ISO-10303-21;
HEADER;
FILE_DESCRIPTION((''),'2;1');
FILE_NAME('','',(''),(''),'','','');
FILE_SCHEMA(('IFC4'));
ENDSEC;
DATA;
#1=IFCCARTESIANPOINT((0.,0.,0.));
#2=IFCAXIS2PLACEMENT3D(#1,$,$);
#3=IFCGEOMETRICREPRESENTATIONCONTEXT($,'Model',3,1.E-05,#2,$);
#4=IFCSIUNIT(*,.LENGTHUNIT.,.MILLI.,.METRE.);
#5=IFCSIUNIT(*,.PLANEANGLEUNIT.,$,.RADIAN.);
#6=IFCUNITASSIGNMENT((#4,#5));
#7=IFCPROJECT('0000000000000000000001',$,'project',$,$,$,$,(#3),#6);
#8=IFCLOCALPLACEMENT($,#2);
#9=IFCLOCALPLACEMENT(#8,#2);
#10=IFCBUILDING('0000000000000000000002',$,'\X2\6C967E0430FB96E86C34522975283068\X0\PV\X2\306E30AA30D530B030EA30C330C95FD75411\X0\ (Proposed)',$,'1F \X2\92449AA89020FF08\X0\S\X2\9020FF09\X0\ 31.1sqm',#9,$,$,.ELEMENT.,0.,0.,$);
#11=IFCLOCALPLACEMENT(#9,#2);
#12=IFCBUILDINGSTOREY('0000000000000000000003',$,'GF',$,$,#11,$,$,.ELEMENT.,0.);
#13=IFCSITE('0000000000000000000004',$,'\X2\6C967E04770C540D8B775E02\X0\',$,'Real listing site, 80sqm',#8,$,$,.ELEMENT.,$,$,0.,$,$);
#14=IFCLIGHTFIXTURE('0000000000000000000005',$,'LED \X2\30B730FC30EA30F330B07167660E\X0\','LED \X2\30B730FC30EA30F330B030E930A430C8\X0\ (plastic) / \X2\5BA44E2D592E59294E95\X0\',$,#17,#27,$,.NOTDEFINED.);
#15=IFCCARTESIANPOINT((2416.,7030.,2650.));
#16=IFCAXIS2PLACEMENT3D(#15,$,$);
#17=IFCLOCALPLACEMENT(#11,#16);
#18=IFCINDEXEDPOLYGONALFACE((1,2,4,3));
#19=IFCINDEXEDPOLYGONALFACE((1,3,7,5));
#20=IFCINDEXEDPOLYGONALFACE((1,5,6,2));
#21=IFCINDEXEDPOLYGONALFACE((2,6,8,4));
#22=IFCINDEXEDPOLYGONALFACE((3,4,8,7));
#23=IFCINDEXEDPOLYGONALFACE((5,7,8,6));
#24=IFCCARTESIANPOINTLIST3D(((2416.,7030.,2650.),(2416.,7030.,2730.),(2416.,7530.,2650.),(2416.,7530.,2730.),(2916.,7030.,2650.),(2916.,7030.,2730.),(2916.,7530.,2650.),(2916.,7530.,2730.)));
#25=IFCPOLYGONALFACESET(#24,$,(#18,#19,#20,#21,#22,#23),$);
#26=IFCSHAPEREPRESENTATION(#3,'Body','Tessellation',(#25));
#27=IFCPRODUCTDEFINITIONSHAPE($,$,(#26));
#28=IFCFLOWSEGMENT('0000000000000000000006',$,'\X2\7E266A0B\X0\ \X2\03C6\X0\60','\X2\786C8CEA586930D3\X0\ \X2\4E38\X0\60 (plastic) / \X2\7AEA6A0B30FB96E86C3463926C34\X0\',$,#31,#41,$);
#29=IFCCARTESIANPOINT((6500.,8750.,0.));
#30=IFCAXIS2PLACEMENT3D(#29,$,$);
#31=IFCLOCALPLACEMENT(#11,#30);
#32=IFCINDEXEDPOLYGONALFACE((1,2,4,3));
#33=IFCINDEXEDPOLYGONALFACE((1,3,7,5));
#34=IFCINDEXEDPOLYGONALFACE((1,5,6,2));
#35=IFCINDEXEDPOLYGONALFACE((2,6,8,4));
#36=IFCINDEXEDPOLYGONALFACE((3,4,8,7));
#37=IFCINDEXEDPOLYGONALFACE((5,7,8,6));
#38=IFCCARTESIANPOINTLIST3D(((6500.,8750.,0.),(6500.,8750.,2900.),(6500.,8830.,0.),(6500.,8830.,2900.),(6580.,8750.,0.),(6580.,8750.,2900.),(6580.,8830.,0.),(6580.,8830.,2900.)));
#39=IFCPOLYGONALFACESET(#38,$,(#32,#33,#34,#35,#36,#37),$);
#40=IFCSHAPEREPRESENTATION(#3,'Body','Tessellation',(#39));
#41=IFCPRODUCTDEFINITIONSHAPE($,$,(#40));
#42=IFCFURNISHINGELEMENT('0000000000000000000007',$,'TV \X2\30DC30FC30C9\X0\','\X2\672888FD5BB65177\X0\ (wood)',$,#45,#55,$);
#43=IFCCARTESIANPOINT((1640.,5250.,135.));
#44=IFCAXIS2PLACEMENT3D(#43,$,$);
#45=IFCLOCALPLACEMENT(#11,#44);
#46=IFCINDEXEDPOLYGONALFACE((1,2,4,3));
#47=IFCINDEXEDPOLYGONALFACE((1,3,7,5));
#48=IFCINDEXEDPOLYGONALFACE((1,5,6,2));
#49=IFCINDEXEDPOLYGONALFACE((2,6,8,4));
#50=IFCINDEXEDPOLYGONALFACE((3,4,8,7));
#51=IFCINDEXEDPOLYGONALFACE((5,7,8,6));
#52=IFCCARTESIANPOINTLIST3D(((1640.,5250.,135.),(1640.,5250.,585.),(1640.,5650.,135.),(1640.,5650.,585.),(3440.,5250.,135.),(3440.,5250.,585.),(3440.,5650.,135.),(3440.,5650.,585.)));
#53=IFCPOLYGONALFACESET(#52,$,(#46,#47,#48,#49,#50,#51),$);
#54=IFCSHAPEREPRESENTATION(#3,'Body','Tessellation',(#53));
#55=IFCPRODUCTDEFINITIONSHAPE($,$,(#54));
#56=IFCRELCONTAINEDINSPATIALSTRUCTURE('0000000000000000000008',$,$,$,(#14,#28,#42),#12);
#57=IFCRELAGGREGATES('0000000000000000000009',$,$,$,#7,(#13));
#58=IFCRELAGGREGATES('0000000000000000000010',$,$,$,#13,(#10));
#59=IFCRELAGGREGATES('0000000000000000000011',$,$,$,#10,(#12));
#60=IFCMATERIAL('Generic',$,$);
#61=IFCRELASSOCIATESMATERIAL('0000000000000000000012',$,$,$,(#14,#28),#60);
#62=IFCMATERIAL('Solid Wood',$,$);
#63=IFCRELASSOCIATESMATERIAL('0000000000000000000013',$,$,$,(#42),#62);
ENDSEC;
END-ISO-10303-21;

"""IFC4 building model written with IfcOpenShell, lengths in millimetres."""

from ifc_helpers import new_model, si_unit, frame, frame_2d, origin, place, context, project, spatial, rectangle, extrude, material, element, save


model = new_model("IFC4")

# Units and contexts
model_context = context("Model", 3, precision=1e-05, world=origin())
ifc_project = project(units=[si_unit("LENGTHUNIT", "METRE", prefix="MILLI"), si_unit("PLANEANGLEUNIT", "RADIAN")], contexts=[model_context])

# Site, building, storey
site_placement = place(None, origin())
site = spatial("IfcSite", under=ifc_project, at=site_placement, Name="沖縄県名護市", ObjectType="Real listing site, 80sqm", CompositionType="ELEMENT", RefElevation=0.0)
building_placement = place(site_placement, origin())
building = spatial("IfcBuilding", under=site, at=building_placement, Name="沖縄・雨水利用とPVのオフグリッド志向 (Proposed)", ObjectType="1F 鉄骨造（S造） 31.1sqm", CompositionType="ELEMENT", ElevationOfRefHeight=0.0, ElevationOfTerrain=0.0)
storey_placement = place(building_placement, origin())
storey = spatial("IfcBuildingStorey", under=building, at=storey_placement, Name="GF", CompositionType="ELEMENT", Elevation=0.0)

# Shared definitions
ifc_material_1 = material(Name="Solid Wood")

# Shared definitions
ifc_material_2 = material(Name="Generic")

# Light fixture
light_fixture_1_placement = place(storey_placement, frame((2416.0, 7030.0, 2650.0)))
element("IfcLightFixture", 1, at=light_fixture_1_placement, inside=storey, material=ifc_material_2, Name="LED シーリング照明", Description="LED シーリングライト (plastic) / 室中央天井", PredefinedType="NOTDEFINED", context=model_context, shape_type="SweptSolid", body=[
    extrude(rectangle(XDim=500.0, YDim=500.0, at=frame_2d((250.0, 250.0))), frame((2416.0, 7030.0, 2650.0)), (0.0, 0.0, 1.0), 80.0),
])

# Flow segment
flow_segment_placement = place(storey_placement, frame((6500.0, 8750.0, 0.0)))
element("IfcFlowSegment", 2, at=flow_segment_placement, inside=storey, material=ifc_material_2, Name="縦樋 φ60", Description="硬質塩ビ 丸60 (plastic) / 竪樋・雨水排水", context=model_context, shape_type="SweptSolid", body=[
    extrude(rectangle(XDim=80.0, YDim=80.0, at=frame_2d((40.0, 40.0))), frame((6500.0, 8750.0, 0.0)), (0.0, 0.0, 1.0), 2900.0),
])

# Furnishing element
furnishing_placement = place(storey_placement, frame((1640.0, 5250.0, 135.0)))
element("IfcFurnishingElement", 3, at=furnishing_placement, inside=storey, material=ifc_material_1, Name="TV ボード", Description="木製家具 (wood)", context=model_context, shape_type="SweptSolid", body=[
    extrude(rectangle(XDim=1800.0, YDim=400.0, at=frame_2d((900.0, 200.0))), frame((1640.0, 5250.0, 135.0)), (0.0, 0.0, 1.0), 450.0),
])

save(model, "model.ifc")
